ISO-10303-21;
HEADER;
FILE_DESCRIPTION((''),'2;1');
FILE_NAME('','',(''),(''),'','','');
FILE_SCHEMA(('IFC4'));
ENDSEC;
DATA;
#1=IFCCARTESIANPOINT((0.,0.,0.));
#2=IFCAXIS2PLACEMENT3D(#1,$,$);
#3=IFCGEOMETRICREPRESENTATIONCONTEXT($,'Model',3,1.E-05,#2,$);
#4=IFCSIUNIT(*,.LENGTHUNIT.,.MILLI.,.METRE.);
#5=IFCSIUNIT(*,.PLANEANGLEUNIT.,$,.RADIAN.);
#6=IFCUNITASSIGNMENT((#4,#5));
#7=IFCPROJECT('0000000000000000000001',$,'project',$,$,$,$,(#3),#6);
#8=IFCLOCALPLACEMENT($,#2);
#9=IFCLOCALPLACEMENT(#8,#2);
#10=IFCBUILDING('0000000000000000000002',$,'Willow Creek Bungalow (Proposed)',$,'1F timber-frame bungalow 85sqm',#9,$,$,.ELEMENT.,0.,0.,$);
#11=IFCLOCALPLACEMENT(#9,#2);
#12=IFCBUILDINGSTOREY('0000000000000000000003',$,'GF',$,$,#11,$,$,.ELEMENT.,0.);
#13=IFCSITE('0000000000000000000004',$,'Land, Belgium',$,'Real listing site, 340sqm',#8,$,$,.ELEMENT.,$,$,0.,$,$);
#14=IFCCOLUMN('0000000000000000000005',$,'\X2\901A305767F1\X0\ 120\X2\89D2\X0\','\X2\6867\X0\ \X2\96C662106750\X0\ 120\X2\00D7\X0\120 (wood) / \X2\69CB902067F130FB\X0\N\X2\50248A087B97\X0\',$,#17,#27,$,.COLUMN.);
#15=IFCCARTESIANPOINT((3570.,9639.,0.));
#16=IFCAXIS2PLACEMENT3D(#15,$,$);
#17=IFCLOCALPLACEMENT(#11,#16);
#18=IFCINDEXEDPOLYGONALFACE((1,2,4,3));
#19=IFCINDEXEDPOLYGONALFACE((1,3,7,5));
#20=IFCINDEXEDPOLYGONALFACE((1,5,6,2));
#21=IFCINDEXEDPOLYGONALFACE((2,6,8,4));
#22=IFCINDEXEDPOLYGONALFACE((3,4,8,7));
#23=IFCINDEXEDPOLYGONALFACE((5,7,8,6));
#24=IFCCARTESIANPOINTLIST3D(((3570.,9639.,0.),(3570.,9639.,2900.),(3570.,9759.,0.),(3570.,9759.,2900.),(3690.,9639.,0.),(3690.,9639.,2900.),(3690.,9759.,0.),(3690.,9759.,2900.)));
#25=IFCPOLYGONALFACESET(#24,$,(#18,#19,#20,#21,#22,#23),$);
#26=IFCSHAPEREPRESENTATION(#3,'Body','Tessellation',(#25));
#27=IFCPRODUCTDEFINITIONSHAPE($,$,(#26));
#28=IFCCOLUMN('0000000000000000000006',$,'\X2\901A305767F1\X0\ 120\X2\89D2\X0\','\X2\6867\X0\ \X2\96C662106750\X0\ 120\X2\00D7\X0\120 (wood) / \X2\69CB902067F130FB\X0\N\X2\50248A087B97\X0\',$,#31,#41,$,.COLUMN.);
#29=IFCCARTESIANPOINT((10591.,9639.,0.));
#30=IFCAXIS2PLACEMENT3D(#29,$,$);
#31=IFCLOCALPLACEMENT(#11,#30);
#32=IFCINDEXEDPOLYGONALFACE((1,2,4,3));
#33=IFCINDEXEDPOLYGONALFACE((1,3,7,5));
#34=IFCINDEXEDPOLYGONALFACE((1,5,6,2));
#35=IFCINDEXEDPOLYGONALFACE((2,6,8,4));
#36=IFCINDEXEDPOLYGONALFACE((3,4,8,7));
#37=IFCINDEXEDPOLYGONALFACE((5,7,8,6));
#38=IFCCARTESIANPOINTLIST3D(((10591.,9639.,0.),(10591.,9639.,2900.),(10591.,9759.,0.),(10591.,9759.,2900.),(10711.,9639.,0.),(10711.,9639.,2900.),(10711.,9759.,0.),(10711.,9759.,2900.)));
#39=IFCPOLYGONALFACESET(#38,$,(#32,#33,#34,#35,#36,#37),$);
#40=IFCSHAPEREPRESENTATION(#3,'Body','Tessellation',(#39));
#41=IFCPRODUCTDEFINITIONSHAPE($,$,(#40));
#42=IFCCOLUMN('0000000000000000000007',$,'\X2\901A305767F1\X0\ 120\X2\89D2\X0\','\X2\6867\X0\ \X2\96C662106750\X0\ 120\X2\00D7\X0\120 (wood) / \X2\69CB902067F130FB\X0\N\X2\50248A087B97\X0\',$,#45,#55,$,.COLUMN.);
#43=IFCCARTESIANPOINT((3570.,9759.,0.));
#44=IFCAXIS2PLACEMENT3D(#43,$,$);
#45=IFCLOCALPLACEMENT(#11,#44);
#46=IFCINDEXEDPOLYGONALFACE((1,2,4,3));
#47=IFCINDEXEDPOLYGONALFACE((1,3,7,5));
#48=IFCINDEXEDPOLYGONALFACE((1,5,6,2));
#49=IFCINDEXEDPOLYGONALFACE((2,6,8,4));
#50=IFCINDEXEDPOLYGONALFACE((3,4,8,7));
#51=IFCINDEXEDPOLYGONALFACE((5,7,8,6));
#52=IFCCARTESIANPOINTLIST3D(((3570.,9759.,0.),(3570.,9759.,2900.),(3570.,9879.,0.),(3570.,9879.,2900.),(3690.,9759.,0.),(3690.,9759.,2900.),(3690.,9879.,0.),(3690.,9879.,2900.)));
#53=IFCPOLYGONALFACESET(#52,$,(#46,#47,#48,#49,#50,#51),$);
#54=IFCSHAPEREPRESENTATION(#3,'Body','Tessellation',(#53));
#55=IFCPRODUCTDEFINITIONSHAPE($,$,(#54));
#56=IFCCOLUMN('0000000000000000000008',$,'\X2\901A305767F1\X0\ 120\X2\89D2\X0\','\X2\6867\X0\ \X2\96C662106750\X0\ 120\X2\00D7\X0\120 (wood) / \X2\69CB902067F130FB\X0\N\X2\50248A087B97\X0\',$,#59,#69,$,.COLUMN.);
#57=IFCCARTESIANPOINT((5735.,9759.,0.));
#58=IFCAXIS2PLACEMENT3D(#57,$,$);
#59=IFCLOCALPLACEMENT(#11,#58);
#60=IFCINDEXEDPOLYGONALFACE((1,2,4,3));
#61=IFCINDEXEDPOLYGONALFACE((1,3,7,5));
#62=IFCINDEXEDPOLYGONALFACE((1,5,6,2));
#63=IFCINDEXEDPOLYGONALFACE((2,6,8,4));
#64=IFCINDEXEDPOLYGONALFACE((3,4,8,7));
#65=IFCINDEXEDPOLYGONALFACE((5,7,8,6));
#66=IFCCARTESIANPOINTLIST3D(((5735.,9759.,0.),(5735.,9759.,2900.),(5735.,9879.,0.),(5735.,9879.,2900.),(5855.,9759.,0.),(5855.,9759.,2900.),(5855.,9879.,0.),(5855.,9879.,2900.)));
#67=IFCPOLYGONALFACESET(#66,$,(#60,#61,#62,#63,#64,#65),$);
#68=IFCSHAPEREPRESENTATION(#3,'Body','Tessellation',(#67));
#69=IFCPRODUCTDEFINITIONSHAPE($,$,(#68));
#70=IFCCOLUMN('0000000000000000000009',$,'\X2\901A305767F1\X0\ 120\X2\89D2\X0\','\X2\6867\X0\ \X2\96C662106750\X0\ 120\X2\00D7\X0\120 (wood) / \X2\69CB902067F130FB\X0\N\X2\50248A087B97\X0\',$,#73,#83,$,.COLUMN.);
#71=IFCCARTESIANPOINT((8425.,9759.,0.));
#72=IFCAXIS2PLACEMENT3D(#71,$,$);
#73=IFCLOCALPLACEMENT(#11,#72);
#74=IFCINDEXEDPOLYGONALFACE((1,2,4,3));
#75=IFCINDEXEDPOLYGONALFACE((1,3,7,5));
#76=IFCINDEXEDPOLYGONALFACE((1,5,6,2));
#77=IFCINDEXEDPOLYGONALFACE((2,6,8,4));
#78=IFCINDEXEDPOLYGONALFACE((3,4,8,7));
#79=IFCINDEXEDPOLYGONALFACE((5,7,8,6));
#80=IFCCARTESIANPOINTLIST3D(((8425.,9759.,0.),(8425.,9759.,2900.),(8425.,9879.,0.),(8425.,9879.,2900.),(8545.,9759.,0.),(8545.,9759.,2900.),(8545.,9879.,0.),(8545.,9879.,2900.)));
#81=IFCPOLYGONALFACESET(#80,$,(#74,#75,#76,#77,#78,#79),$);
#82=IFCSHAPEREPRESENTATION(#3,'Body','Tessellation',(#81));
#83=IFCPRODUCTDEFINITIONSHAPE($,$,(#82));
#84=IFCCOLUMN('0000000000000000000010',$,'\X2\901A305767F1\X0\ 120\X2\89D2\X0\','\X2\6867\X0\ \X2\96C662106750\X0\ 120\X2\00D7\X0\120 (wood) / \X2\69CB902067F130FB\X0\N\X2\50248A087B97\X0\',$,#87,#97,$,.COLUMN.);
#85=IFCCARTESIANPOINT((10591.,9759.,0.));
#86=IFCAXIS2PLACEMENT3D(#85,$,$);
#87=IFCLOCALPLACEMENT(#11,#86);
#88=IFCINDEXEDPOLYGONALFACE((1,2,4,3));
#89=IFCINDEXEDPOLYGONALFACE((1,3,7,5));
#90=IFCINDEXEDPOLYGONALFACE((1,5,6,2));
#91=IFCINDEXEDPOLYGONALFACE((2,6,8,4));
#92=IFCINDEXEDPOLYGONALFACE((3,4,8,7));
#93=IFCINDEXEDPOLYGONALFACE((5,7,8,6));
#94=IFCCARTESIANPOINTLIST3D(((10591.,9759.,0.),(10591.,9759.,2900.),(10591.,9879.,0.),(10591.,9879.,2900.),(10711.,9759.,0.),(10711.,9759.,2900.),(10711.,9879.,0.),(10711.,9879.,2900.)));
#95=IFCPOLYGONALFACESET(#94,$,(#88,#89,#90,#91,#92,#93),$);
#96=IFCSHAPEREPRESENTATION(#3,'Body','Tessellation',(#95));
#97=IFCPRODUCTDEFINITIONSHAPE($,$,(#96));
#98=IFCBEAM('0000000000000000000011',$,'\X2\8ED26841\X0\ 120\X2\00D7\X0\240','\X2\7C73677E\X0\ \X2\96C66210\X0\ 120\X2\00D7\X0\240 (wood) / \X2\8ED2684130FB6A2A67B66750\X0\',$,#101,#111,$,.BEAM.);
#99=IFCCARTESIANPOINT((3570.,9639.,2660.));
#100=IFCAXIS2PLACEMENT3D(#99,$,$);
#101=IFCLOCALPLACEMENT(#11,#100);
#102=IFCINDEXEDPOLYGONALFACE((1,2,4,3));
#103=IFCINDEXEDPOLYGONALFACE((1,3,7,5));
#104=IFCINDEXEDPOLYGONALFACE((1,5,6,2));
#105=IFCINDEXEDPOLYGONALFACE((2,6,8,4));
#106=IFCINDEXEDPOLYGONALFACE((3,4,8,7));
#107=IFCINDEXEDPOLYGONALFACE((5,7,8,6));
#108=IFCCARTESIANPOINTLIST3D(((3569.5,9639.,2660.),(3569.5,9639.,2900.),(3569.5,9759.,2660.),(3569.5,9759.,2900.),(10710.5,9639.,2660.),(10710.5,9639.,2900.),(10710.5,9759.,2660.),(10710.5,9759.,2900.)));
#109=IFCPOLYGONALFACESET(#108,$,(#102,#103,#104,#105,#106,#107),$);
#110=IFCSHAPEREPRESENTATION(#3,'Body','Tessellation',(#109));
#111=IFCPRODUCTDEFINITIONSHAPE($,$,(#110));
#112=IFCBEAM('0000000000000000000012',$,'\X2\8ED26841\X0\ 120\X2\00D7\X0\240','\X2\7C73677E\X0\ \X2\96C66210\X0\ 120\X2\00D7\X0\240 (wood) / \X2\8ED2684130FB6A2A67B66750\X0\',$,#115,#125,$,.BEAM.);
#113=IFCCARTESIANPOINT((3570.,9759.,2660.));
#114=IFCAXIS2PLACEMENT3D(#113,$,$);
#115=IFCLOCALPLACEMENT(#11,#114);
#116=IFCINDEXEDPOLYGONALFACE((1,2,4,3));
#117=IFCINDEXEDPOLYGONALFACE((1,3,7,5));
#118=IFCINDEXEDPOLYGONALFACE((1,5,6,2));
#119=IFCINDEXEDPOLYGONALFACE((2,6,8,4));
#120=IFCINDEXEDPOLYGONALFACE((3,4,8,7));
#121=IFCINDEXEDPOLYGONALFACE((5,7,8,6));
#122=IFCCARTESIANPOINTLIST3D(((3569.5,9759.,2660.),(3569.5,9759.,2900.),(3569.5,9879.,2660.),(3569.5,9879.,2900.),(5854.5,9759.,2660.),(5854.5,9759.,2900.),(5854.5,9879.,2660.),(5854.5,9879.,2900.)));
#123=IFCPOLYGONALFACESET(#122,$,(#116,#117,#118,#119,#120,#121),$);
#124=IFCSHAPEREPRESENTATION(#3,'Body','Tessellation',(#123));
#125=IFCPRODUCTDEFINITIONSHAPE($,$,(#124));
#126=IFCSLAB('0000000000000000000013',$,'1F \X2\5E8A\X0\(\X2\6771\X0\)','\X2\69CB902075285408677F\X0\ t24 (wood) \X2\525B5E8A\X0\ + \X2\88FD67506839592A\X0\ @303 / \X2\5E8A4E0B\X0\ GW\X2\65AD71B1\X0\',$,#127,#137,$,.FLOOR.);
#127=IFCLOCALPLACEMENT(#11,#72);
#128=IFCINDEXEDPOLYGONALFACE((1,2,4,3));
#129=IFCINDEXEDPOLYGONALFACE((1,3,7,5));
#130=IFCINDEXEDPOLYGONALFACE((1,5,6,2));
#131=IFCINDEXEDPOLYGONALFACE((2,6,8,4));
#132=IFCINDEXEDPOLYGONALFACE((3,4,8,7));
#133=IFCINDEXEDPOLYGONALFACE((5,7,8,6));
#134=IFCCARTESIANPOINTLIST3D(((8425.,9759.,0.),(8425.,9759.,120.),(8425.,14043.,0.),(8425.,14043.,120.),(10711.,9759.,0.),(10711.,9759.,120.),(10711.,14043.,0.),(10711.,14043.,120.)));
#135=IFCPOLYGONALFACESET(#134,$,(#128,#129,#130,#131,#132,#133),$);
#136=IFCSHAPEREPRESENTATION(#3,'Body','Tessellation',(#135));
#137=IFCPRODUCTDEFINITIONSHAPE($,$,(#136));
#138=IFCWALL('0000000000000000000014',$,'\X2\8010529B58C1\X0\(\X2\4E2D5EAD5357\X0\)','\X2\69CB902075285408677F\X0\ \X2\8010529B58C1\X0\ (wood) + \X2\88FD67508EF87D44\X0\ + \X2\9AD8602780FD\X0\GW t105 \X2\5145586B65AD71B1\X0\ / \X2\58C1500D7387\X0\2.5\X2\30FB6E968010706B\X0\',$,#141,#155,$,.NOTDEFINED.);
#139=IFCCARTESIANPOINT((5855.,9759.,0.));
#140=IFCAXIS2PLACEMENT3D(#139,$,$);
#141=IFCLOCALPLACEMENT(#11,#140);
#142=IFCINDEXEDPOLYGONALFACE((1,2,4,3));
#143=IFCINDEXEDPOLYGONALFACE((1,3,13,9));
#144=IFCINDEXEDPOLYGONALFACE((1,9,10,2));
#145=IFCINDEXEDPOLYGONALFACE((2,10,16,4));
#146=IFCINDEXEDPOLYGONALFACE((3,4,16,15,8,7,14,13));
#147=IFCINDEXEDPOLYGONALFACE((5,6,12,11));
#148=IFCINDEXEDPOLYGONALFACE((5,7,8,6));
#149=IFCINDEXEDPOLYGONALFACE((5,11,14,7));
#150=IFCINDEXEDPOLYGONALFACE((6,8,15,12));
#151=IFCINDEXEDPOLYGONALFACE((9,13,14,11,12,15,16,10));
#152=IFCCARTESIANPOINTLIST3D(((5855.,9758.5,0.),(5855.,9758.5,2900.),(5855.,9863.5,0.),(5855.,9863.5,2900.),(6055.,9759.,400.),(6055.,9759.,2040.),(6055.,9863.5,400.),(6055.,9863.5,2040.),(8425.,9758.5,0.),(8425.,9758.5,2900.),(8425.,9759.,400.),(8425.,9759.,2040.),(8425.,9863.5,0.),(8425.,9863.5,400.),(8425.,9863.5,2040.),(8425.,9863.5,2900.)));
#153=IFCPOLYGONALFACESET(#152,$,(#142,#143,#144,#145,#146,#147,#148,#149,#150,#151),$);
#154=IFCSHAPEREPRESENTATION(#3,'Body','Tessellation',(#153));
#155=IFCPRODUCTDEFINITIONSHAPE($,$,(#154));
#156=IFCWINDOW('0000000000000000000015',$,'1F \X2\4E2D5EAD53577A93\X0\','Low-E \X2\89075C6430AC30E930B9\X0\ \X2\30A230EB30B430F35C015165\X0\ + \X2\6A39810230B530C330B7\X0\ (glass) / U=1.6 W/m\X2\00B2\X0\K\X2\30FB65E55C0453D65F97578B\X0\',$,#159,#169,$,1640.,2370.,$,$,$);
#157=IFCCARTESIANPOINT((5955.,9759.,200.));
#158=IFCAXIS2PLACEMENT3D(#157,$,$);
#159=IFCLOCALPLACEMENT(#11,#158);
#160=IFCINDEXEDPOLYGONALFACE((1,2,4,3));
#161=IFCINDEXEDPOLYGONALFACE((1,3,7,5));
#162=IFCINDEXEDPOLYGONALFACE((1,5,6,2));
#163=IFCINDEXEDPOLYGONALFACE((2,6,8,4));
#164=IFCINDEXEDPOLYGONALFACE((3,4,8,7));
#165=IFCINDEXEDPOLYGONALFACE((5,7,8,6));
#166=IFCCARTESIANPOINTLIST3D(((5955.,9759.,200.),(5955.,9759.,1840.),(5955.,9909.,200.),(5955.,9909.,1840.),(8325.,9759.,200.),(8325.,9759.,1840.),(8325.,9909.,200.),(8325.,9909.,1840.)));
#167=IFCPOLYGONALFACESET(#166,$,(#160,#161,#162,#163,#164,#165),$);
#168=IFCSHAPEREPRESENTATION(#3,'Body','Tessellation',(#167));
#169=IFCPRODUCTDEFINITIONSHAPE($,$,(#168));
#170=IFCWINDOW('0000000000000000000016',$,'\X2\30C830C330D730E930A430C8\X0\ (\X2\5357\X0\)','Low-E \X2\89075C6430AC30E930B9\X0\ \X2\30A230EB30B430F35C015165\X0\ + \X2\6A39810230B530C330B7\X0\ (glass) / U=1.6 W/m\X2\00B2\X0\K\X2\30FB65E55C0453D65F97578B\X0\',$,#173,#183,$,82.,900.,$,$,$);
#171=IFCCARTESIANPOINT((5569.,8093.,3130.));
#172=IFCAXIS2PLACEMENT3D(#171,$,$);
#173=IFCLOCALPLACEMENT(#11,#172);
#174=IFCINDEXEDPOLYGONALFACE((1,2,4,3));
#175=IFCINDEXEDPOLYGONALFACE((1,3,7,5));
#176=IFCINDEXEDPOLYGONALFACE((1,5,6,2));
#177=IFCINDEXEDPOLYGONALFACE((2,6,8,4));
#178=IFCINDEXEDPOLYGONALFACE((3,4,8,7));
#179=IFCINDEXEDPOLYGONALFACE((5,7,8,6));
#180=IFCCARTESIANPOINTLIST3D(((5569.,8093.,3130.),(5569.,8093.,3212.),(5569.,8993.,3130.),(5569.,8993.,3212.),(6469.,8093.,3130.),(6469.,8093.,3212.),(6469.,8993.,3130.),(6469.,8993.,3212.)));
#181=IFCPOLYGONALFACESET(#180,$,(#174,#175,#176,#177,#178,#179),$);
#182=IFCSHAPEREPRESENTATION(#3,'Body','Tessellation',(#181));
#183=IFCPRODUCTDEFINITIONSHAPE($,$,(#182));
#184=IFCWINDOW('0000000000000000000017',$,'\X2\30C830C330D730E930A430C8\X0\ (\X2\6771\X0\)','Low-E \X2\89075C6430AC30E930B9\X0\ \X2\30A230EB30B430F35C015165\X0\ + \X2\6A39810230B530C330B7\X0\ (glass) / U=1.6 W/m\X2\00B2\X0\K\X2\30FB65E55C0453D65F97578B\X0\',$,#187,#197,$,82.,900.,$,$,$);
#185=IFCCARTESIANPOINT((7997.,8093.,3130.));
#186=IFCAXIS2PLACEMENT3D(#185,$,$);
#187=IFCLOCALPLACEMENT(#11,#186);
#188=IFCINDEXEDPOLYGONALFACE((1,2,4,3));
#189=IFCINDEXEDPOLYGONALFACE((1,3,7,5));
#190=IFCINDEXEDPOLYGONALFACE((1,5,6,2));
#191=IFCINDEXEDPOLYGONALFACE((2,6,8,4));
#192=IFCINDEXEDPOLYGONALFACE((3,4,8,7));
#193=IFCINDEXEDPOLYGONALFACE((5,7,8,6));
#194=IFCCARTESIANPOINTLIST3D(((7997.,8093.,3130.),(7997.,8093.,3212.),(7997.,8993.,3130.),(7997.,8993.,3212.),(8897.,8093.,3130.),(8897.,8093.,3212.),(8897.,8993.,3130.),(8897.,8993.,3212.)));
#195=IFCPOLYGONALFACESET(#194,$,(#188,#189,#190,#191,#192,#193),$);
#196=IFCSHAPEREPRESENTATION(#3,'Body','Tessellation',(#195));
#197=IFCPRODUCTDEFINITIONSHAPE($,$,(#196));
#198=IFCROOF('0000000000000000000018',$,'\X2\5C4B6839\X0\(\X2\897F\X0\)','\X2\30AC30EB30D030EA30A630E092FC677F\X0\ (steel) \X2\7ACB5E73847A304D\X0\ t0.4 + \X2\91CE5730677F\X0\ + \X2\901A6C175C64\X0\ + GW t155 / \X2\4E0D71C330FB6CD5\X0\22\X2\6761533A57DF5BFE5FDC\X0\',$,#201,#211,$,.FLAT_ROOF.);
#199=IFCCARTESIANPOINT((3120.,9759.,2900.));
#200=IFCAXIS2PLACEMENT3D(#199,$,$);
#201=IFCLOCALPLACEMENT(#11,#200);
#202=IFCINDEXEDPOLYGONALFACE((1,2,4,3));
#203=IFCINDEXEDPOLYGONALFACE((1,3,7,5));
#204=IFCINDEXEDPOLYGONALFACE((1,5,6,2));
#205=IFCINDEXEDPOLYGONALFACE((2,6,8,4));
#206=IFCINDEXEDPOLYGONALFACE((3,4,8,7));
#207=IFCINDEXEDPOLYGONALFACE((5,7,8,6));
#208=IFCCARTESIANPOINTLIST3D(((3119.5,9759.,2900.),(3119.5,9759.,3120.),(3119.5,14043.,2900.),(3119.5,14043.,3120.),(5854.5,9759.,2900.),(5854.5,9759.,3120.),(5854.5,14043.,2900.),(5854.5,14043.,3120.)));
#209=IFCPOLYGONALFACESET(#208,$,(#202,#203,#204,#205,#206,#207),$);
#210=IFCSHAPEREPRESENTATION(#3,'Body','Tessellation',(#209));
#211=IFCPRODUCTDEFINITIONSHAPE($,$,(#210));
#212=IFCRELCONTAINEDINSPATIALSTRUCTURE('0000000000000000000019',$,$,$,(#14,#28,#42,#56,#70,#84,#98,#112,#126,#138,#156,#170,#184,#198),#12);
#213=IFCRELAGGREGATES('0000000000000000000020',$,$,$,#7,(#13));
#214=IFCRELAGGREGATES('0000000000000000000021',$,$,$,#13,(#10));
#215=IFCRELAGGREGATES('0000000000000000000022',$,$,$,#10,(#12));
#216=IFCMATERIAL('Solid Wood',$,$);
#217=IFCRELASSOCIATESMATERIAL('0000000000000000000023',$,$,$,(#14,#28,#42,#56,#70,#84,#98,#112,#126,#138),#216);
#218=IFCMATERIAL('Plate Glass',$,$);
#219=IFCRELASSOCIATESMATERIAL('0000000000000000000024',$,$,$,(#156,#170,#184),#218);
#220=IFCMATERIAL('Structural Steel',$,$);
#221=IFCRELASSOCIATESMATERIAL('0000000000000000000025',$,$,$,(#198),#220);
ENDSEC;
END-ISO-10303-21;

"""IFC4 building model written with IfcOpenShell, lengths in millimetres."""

from ifc_helpers import new_model, si_unit, frame, frame_2d, origin, place, context, project, spatial, rectangle, extrude, material, element, fill, save


model = new_model("IFC4")

# Units and contexts
model_context = context("Model", 3, precision=1e-05, world=origin())
ifc_project = project(units=[si_unit("LENGTHUNIT", "METRE", prefix="MILLI"), si_unit("PLANEANGLEUNIT", "RADIAN")], contexts=[model_context])

# Site, building, storey
site_placement = place(None, origin())
site = spatial("IfcSite", under=ifc_project, at=site_placement, Name="Land, Belgium", ObjectType="Real listing site, 340sqm", CompositionType="ELEMENT", RefElevation=0.0)
building_placement = place(site_placement, origin())
building = spatial("IfcBuilding", under=site, at=building_placement, Name="Willow Creek Bungalow (Proposed)", ObjectType="1F timber-frame bungalow 85sqm", CompositionType="ELEMENT", ElevationOfRefHeight=0.0, ElevationOfTerrain=0.0)
storey_placement = place(building_placement, origin())
storey = spatial("IfcBuildingStorey", under=building, at=storey_placement, Name="GF", CompositionType="ELEMENT", Elevation=0.0)

# Columns
ifc_material_1 = material(Name="Solid Wood")
column_1_placement = place(storey_placement, frame((3570.0, 9639.0, 0.0)))
element("IfcColumn", 1, at=column_1_placement, inside=storey, material=ifc_material_1, Name="通し柱 120角", Description="桧 集成材 120×120 (wood) / 構造柱・N値計算", PredefinedType="COLUMN", context=model_context, shape_type="SweptSolid", body=[
    extrude(rectangle(XDim=120.0, YDim=120.0, at=frame_2d((60.0, 60.0))), frame((3570.0, 9639.0, 0.0)), (0.0, 0.0, 1.0), 2900.0),
])
column_2_placement = place(storey_placement, frame((10591.0, 9639.0, 0.0)))
element("IfcColumn", 2, at=column_2_placement, inside=storey, material=ifc_material_1, Name="通し柱 120角", Description="桧 集成材 120×120 (wood) / 構造柱・N値計算", PredefinedType="COLUMN", context=model_context, shape_type="SweptSolid", body=[
    extrude(rectangle(XDim=120.0, YDim=120.0, at=frame_2d((60.0, 60.0))), frame((10591.0, 9639.0, 0.0)), (0.0, 0.0, 1.0), 2900.0),
])
column_3_placement = place(storey_placement, frame((3570.0, 9759.0, 0.0)))
element("IfcColumn", 3, at=column_3_placement, inside=storey, material=ifc_material_1, Name="通し柱 120角", Description="桧 集成材 120×120 (wood) / 構造柱・N値計算", PredefinedType="COLUMN", context=model_context, shape_type="SweptSolid", body=[
    extrude(rectangle(XDim=120.0, YDim=120.0, at=frame_2d((60.0, 60.0))), frame((3570.0, 9759.0, 0.0)), (0.0, 0.0, 1.0), 2900.0),
])
column_4_placement = place(storey_placement, frame((5735.0, 9759.0, 0.0)))
element("IfcColumn", 4, at=column_4_placement, inside=storey, material=ifc_material_1, Name="通し柱 120角", Description="桧 集成材 120×120 (wood) / 構造柱・N値計算", PredefinedType="COLUMN", context=model_context, shape_type="SweptSolid", body=[
    extrude(rectangle(XDim=120.0, YDim=120.0, at=frame_2d((60.0, 60.0))), frame((5735.0, 9759.0, 0.0)), (0.0, 0.0, 1.0), 2900.0),
])
column_5_placement = place(storey_placement, frame((8425.0, 9759.0, 0.0)))
element("IfcColumn", 5, at=column_5_placement, inside=storey, material=ifc_material_1, Name="通し柱 120角", Description="桧 集成材 120×120 (wood) / 構造柱・N値計算", PredefinedType="COLUMN", context=model_context, shape_type="SweptSolid", body=[
    extrude(rectangle(XDim=120.0, YDim=120.0, at=frame_2d((60.0, 60.0))), frame((8425.0, 9759.0, 0.0)), (0.0, 0.0, 1.0), 2900.0),
])
column_6_placement = place(storey_placement, frame((10591.0, 9759.0, 0.0)))
element("IfcColumn", 6, at=column_6_placement, inside=storey, material=ifc_material_1, Name="通し柱 120角", Description="桧 集成材 120×120 (wood) / 構造柱・N値計算", PredefinedType="COLUMN", context=model_context, shape_type="SweptSolid", body=[
    extrude(rectangle(XDim=120.0, YDim=120.0, at=frame_2d((60.0, 60.0))), frame((10591.0, 9759.0, 0.0)), (0.0, 0.0, 1.0), 2900.0),
])

# Beams
beam_1_placement = place(storey_placement, frame((3570.0, 9639.0, 2660.0)))
element("IfcBeam", 7, at=beam_1_placement, inside=storey, material=ifc_material_1, Name="軒桁 120×240", Description="米松 集成 120×240 (wood) / 軒桁・横架材", PredefinedType="BEAM", context=model_context, shape_type="SweptSolid", body=[
    extrude(rectangle(XDim=7141.0, YDim=120.0, at=frame_2d((3570.0, 60.0))), frame((3570.0, 9639.0, 2660.0)), (0.0, 0.0, 1.0), 240.0),
])
beam_2_placement = place(storey_placement, frame((3570.0, 9759.0, 2660.0)))
element("IfcBeam", 8, at=beam_2_placement, inside=storey, material=ifc_material_1, Name="軒桁 120×240", Description="米松 集成 120×240 (wood) / 軒桁・横架材", PredefinedType="BEAM", context=model_context, shape_type="SweptSolid", body=[
    extrude(rectangle(XDim=2285.0, YDim=120.0, at=frame_2d((1142.0, 60.0))), frame((3570.0, 9759.0, 2660.0)), (0.0, 0.0, 1.0), 240.0),
])

# Slab
slab_1_placement = place(storey_placement, frame((8425.0, 9759.0, 0.0)))
element("IfcSlab", 9, at=slab_1_placement, inside=storey, material=ifc_material_1, Name="1F 床(東)", Description="構造用合板 t24 (wood) 剛床 + 製材根太 @303 / 床下 GW断熱", PredefinedType="FLOOR", context=model_context, shape_type="SweptSolid", body=[
    extrude(rectangle(XDim=2286.0, YDim=4284.0, at=frame_2d((1143.0, 2142.0))), frame((8425.0, 9759.0, 0.0)), (0.0, 0.0, 1.0), 120.0),
])

# Wall, opening, window
wall_1_placement = place(storey_placement, frame((5855.0, 9759.0, 0.0)))
wall_1 = element("IfcWall", 10, at=wall_1_placement, inside=storey, material=ifc_material_1, Name="耐力壁(中庭南)", Description="構造用合板 耐力壁 (wood) + 製材軸組 + 高性能GW t105 充填断熱 / 壁倍率2.5・準耐火", PredefinedType="NOTDEFINED", context=model_context, shape_type="SweptSolid", body=[
    extrude(rectangle(XDim=2570.0, YDim=105.0, at=frame_2d((1285.0, 52.0))), frame((5855.0, 9759.0, 0.0)), (0.0, 0.0, 1.0), 2900.0),
])
opening_placement = place(storey_placement, frame((5955.0, 9759.0, 200.0)))
opening = element("IfcOpeningElement", 11, at=opening_placement, cuts=wall_1, PredefinedType="NOTDEFINED", context=model_context, shape_type="SweptSolid", body=[
    extrude(rectangle(XDim=2370.0, YDim=150.0, at=frame_2d((1185.0, 75.0))), frame((5955.0, 9759.0, 200.0)), (0.0, 0.0, 1.0), 1640.0),
])
ifc_material_2 = material(Name="Plate Glass")
window_1_placement = place(storey_placement, frame((5955.0, 9759.0, 200.0)))
window_1 = element("IfcWindow", 12, at=window_1_placement, inside=storey, material=ifc_material_2, Name="1F 中庭南窓", Description="Low-E 複層ガラス アルゴン封入 + 樹脂サッシ (glass) / U=1.6 W/m²K・日射取得型", OverallHeight=1640.0, OverallWidth=2370.0, context=model_context, shape_type="SweptSolid", body=[
    extrude(rectangle(XDim=2370.0, YDim=150.0, at=frame_2d((1185.0, 75.0))), frame((5955.0, 9759.0, 200.0)), (0.0, 0.0, 1.0), 1640.0),
])
fill(opening, window_1)

# Windows
window_2_placement = place(storey_placement, frame((5569.0, 8093.0, 3130.0)))
element("IfcWindow", 13, at=window_2_placement, inside=storey, material=ifc_material_2, Name="トップライト (南)", Description="Low-E 複層ガラス アルゴン封入 + 樹脂サッシ (glass) / U=1.6 W/m²K・日射取得型", OverallHeight=82.0, OverallWidth=900.0, context=model_context, shape_type="SweptSolid", body=[
    extrude(rectangle(XDim=900.0, YDim=900.0, at=frame_2d((450.0, 450.0))), frame((5569.0, 8093.0, 3130.0)), (0.0, 0.0, 1.0), 82.0),
])
window_3_placement = place(storey_placement, frame((7997.0, 8093.0, 3130.0)))
element("IfcWindow", 14, at=window_3_placement, inside=storey, material=ifc_material_2, Name="トップライト (東)", Description="Low-E 複層ガラス アルゴン封入 + 樹脂サッシ (glass) / U=1.6 W/m²K・日射取得型", OverallHeight=82.0, OverallWidth=900.0, context=model_context, shape_type="SweptSolid", body=[
    extrude(rectangle(XDim=900.0, YDim=900.0, at=frame_2d((450.0, 450.0))), frame((7997.0, 8093.0, 3130.0)), (0.0, 0.0, 1.0), 82.0),
])

# Roof
ifc_material_3 = material(Name="Structural Steel")
roof_1_placement = place(storey_placement, frame((3120.0, 9759.0, 2900.0)))
element("IfcRoof", 15, at=roof_1_placement, inside=storey, material=ifc_material_3, Name="屋根(西)", Description="ガルバリウム鋼板 (steel) 立平葺き t0.4 + 野地板 + 通気層 + GW t155 / 不燃・法22条区域対応", PredefinedType="FLAT_ROOF", context=model_context, shape_type="SweptSolid", body=[
    extrude(rectangle(XDim=2735.0, YDim=4284.0, at=frame_2d((1367.0, 2142.0))), frame((3120.0, 9759.0, 2900.0)), (0.0, 0.0, 1.0), 220.0),
])

save(model, "model.ifc")
